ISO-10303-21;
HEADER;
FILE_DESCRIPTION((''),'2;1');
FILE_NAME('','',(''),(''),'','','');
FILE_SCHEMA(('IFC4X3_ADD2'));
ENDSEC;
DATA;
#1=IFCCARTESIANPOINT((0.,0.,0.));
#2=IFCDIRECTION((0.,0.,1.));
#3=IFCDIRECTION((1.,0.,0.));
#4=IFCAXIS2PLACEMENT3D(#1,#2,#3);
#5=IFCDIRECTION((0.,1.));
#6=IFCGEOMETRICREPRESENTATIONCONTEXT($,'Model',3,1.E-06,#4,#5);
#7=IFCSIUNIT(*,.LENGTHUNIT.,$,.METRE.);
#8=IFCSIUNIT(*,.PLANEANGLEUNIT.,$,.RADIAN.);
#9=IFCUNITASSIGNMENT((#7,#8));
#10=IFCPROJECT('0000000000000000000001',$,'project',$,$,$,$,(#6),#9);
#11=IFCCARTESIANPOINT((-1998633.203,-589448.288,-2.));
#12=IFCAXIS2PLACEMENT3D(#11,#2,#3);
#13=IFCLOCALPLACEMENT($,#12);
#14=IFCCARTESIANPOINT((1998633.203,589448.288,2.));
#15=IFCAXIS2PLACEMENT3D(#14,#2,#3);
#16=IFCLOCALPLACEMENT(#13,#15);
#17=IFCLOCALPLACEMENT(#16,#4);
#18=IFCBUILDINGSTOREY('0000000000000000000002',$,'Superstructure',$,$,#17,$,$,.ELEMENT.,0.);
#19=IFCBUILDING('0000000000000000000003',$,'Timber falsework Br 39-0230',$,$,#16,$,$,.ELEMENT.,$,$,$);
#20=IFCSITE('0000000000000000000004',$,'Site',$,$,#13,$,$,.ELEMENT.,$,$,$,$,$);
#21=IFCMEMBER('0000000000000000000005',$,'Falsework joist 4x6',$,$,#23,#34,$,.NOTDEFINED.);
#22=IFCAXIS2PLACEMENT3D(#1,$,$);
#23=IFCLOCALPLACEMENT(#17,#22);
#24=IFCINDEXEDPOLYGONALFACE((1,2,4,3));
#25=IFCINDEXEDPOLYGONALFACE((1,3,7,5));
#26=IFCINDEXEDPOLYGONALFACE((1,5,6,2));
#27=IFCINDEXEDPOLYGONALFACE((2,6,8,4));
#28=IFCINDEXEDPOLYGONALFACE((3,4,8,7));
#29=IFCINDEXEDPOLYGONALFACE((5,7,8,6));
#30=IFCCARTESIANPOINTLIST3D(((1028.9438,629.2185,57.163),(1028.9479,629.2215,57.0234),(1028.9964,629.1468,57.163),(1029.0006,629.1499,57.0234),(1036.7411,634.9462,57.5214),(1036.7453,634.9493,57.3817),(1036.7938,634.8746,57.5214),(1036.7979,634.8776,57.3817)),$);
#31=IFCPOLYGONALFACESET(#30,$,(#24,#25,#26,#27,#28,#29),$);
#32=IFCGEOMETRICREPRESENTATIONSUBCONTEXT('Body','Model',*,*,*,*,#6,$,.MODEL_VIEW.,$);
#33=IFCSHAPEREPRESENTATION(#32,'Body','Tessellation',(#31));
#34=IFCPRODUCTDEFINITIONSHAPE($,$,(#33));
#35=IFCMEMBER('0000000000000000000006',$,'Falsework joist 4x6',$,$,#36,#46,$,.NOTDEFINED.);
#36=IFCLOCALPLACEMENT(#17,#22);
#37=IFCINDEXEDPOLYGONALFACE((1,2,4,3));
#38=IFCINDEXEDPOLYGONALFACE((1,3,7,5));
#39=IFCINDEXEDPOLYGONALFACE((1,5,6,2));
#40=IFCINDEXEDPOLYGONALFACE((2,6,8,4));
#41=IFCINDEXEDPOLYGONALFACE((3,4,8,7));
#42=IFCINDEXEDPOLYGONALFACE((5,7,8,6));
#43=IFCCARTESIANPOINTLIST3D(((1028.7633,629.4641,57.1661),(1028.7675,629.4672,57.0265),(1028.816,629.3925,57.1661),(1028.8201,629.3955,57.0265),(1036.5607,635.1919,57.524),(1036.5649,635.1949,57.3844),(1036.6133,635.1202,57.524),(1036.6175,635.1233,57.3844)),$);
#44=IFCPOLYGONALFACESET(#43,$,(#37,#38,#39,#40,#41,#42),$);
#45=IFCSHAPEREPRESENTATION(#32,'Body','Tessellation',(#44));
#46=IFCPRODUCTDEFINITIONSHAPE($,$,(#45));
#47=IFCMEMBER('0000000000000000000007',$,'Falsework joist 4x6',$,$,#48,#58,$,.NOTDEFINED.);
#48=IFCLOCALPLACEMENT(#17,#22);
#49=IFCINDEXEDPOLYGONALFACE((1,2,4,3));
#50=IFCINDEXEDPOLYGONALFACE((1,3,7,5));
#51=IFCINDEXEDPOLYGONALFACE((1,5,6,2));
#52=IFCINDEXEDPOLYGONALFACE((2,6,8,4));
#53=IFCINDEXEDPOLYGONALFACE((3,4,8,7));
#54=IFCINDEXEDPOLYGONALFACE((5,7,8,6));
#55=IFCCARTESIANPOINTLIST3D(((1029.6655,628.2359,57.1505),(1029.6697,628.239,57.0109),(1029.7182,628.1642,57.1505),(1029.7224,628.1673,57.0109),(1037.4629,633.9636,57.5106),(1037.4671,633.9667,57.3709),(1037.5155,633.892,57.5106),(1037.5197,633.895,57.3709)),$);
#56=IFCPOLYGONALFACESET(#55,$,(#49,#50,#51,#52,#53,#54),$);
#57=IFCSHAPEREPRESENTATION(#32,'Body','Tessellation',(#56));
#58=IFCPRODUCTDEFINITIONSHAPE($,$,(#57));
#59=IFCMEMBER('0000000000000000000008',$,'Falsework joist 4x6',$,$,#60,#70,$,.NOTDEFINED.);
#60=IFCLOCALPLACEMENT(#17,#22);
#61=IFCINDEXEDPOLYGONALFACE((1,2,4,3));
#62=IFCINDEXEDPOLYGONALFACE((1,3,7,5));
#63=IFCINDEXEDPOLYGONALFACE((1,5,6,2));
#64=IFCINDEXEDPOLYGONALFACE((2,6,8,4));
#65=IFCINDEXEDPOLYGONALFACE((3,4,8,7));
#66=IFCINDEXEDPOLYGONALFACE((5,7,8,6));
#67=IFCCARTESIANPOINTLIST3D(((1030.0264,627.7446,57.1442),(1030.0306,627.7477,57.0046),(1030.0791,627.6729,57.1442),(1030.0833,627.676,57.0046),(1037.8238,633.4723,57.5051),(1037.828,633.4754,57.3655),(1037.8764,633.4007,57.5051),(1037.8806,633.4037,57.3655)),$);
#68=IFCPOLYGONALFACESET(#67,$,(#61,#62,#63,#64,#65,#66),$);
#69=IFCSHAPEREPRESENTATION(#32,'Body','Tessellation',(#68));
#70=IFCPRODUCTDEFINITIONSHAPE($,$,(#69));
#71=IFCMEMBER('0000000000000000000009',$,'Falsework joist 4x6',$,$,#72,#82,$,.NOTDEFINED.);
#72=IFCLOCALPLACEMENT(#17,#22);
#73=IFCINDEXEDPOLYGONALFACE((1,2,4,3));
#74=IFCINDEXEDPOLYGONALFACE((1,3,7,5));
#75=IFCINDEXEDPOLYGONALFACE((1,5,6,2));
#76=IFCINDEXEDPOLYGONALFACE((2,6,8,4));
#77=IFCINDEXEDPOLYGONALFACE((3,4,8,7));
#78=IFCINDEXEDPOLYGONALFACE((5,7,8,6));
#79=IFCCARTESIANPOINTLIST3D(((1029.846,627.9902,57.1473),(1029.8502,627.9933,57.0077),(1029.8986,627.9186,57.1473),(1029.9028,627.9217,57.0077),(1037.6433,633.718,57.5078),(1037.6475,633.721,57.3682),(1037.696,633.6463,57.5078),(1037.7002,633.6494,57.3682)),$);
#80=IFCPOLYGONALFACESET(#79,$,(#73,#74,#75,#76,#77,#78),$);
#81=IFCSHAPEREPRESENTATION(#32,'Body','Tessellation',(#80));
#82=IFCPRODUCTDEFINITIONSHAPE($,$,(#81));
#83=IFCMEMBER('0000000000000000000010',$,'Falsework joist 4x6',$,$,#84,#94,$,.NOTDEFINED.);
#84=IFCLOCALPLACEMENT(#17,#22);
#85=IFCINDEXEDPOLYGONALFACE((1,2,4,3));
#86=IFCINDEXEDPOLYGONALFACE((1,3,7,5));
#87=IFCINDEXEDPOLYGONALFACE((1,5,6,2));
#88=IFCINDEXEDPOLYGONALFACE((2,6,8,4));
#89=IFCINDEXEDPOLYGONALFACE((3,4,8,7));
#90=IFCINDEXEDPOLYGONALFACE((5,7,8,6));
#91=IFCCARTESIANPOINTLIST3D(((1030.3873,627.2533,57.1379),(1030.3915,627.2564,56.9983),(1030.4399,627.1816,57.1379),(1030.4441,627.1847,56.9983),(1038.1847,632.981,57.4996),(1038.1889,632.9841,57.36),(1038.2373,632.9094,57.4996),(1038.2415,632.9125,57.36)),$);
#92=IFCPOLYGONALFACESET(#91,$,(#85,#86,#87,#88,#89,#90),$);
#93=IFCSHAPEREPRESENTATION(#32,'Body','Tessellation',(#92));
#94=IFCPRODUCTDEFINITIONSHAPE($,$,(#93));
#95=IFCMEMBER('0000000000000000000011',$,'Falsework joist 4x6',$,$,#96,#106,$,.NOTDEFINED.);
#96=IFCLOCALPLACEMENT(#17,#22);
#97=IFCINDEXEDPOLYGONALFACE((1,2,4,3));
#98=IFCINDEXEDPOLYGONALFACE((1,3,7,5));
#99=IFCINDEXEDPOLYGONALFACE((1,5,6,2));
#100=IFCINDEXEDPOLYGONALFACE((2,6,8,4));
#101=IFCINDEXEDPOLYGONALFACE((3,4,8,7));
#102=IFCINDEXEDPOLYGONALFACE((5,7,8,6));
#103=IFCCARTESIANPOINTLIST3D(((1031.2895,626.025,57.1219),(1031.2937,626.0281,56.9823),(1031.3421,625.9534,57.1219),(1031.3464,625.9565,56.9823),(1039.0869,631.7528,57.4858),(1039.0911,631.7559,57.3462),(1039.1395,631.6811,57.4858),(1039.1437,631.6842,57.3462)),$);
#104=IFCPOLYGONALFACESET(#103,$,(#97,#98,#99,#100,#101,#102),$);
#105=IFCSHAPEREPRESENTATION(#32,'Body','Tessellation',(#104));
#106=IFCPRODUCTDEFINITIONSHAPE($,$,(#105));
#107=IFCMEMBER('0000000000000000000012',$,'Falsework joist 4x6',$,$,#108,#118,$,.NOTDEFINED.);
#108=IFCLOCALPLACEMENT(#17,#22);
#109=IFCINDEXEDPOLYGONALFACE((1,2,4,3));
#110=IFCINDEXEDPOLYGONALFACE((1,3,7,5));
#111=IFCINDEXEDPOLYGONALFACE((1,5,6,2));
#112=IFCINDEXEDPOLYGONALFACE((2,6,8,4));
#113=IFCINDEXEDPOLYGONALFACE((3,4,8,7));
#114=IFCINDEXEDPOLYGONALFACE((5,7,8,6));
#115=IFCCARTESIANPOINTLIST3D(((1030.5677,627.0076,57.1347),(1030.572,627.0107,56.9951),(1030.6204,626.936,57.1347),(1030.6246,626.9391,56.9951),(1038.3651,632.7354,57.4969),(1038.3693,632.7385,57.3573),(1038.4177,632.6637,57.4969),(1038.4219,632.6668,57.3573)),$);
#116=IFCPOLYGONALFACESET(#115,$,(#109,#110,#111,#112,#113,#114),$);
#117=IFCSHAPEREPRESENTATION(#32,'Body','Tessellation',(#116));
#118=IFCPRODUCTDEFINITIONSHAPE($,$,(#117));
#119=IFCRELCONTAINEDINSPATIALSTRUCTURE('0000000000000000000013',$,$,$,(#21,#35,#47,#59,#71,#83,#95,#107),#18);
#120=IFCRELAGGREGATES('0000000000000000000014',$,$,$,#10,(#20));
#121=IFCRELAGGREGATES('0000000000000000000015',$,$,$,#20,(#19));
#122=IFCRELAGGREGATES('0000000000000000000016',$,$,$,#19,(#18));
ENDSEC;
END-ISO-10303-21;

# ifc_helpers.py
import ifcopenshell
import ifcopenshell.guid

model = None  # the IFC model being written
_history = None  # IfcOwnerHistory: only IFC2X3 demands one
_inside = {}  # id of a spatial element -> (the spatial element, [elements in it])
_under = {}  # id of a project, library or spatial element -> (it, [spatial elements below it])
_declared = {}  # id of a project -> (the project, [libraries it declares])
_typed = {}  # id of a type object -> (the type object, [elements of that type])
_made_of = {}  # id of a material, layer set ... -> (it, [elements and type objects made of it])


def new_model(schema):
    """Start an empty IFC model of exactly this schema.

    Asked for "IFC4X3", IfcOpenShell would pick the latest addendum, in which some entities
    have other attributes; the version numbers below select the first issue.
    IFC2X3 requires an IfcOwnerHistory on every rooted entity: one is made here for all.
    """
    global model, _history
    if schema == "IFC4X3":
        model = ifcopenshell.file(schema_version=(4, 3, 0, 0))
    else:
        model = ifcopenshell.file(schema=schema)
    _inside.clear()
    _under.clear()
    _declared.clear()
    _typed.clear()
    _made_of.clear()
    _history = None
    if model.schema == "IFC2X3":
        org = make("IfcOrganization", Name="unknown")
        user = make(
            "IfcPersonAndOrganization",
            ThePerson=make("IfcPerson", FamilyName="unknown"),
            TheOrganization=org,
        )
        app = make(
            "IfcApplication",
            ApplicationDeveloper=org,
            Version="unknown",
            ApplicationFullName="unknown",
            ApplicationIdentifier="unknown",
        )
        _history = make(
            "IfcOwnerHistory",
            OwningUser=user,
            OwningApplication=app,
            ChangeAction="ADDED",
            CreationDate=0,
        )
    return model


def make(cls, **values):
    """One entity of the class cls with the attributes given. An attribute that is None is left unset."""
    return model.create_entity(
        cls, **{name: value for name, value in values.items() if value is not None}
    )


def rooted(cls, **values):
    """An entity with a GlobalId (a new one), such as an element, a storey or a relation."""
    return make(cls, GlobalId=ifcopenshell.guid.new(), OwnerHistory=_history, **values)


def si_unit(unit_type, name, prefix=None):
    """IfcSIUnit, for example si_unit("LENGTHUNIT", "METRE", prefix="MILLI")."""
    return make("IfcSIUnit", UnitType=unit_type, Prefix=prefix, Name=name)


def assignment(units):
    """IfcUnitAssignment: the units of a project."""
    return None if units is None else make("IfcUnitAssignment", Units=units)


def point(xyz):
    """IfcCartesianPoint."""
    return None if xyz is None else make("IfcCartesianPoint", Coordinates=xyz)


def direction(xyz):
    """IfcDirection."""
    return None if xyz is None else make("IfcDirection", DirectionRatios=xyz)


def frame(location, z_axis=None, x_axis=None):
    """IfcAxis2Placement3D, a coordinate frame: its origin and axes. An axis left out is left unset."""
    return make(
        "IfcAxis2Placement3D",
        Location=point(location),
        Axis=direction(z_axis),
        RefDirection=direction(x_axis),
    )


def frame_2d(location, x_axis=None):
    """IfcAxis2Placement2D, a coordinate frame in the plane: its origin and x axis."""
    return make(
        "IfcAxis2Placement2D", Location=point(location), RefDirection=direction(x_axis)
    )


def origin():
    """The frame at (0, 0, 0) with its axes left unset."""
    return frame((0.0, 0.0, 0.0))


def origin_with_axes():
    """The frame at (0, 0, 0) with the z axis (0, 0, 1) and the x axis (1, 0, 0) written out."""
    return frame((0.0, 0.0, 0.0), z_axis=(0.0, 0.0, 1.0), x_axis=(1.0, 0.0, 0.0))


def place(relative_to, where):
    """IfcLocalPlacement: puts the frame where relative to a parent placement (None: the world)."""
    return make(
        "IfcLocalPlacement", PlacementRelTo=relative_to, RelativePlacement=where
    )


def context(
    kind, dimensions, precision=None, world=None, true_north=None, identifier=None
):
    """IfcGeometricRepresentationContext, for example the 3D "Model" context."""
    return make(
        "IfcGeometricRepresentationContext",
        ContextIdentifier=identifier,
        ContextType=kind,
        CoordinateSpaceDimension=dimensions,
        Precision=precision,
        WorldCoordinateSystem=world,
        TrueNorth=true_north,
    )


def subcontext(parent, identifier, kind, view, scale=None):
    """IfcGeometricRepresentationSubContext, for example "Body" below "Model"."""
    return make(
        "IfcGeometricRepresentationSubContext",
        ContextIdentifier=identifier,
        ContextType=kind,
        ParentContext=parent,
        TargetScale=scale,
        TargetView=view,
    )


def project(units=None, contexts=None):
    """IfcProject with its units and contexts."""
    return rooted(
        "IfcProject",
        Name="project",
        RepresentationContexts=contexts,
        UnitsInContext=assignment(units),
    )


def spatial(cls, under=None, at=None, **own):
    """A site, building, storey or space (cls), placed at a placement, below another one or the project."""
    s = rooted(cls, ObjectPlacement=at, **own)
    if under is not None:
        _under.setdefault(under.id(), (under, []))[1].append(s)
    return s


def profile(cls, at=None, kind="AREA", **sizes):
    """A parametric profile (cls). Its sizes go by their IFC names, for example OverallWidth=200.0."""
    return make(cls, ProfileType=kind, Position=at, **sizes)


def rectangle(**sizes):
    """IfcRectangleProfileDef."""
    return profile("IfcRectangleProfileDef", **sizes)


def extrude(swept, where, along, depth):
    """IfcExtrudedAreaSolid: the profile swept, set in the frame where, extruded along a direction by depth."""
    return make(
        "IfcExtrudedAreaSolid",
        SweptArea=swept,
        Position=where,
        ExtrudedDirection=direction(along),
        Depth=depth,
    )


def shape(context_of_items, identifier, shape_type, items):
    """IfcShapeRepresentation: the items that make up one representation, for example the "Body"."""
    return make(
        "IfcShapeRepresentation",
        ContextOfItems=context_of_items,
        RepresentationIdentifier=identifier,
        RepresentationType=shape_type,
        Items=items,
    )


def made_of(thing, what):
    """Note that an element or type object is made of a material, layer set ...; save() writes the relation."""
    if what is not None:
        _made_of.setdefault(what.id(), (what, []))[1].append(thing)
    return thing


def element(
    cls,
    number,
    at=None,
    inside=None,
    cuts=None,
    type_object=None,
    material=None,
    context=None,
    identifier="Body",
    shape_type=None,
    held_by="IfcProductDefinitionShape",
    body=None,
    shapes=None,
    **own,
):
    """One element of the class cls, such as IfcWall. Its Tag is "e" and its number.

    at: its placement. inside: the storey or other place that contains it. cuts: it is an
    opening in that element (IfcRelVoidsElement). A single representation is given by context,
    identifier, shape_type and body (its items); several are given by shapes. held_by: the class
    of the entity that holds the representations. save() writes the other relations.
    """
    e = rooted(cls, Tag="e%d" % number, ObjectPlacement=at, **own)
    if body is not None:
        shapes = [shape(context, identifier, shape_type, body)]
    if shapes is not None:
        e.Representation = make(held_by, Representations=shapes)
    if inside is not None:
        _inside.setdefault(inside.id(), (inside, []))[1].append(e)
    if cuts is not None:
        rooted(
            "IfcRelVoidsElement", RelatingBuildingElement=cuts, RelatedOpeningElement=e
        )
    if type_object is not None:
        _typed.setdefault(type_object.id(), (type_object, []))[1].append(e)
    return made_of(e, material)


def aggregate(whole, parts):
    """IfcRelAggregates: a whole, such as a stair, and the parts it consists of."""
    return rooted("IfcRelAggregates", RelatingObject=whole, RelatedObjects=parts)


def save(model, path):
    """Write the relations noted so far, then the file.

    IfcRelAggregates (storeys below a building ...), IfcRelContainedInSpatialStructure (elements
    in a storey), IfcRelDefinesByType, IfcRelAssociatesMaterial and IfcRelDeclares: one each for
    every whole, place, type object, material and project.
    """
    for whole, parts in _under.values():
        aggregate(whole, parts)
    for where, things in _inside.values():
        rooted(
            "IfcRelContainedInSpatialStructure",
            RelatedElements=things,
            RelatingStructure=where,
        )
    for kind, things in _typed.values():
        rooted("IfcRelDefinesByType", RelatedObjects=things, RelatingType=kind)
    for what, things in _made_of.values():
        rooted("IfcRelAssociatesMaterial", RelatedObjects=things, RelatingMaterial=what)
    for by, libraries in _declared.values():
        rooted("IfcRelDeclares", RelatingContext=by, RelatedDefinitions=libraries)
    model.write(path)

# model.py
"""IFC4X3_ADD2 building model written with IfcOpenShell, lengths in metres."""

from ifc_helpers import new_model, si_unit, direction, frame, frame_2d, origin, origin_with_axes, place, context, subcontext, project, spatial, rectangle, extrude, element, save


model = new_model("IFC4X3_ADD2")

# Units and contexts
model_context = context("Model", 3, precision=1e-06, world=origin_with_axes(), true_north=direction((0.0, 1.0)))
body_context = subcontext(model_context, "Body", "Model", "MODEL_VIEW")
ifc_project = project(units=[si_unit("LENGTHUNIT", "METRE"), si_unit("PLANEANGLEUNIT", "RADIAN")], contexts=[model_context])

# Site, building, storey
site_placement = place(None, frame((-1998633.203, -589448.288, -2.0), z_axis=(0.0, 0.0, 1.0), x_axis=(1.0, 0.0, 0.0)))
site = spatial("IfcSite", under=ifc_project, at=site_placement, Name="Site", CompositionType="ELEMENT")
building_placement = place(site_placement, frame((1998633.203, 589448.288, 2.0), z_axis=(0.0, 0.0, 1.0), x_axis=(1.0, 0.0, 0.0)))
building = spatial("IfcBuilding", under=site, at=building_placement, Name="Timber falsework Br 39-0230", CompositionType="ELEMENT")
storey_placement = place(building_placement, origin_with_axes())
storey = spatial("IfcBuildingStorey", under=building, at=storey_placement, Name="Superstructure", CompositionType="ELEMENT", Elevation=0.0)

# Members
member_1_placement = place(storey_placement, frame((1028.9743, 629.1857, 57.0234), z_axis=(0.805376, 0.591607, 0.037014), x_axis=(-0.592013, 0.805928, 0.0)))
element("IfcMember", 1, at=member_1_placement, inside=storey, Name="Falsework joist 4x6", PredefinedType="NOTDEFINED", context=body_context, shape_type="SweptSolid", body=[
    extrude(rectangle(XDim=0.0889, YDim=0.1397, at=frame_2d((0.0, 0.0698))), origin(), (0.0, 0.0, 1.0), 9.6816),
])
member_2_placement = place(storey_placement, frame((1028.7938, 629.4314, 57.0265), z_axis=(0.805377, 0.591608, 0.036971), x_axis=(-0.592013, 0.805928, 0.0)))
element("IfcMember", 2, at=member_2_placement, inside=storey, Name="Falsework joist 4x6", PredefinedType="NOTDEFINED", context=body_context, shape_type="SweptSolid", body=[
    extrude(rectangle(XDim=0.0889, YDim=0.1397, at=frame_2d((0.0, 0.0698))), origin(), (0.0, 0.0, 1.0), 9.6816),
])
member_3_placement = place(storey_placement, frame((1029.696, 628.2031, 57.0109), z_axis=(0.805371, 0.591604, 0.03719), x_axis=(-0.592013, 0.805928, 0.0)))
element("IfcMember", 3, at=member_3_placement, inside=storey, Name="Falsework joist 4x6", PredefinedType="NOTDEFINED", context=body_context, shape_type="SweptSolid", body=[
    extrude(rectangle(XDim=0.0889, YDim=0.1397, at=frame_2d((0.0, 0.0698))), origin(), (0.0, 0.0, 1.0), 9.6817),
])
member_4_placement = place(storey_placement, frame((1030.0569, 627.7118, 57.0046), z_axis=(0.805368, 0.591602, 0.037277), x_axis=(-0.592013, 0.805928, 0.0)))
element("IfcMember", 4, at=member_4_placement, inside=storey, Name="Falsework joist 4x6", PredefinedType="NOTDEFINED", context=body_context, shape_type="SweptSolid", body=[
    extrude(rectangle(XDim=0.0889, YDim=0.1397, at=frame_2d((0.0, 0.0698))), origin(), (0.0, 0.0, 1.0), 9.6817),
])
member_5_placement = place(storey_placement, frame((1029.8765, 627.9575, 57.0077), z_axis=(0.805369, 0.591603, 0.037233), x_axis=(-0.592013, 0.805928, 0.0)))
element("IfcMember", 5, at=member_5_placement, inside=storey, Name="Falsework joist 4x6", PredefinedType="NOTDEFINED", context=body_context, shape_type="SweptSolid", body=[
    extrude(rectangle(XDim=0.0889, YDim=0.1397, at=frame_2d((0.0, 0.0698))), origin(), (0.0, 0.0, 1.0), 9.6817),
])
member_6_placement = place(storey_placement, frame((1030.4178, 627.2205, 56.9983), z_axis=(0.805366, 0.5916, 0.037364), x_axis=(-0.592013, 0.805928, 0.0)))
element("IfcMember", 6, at=member_6_placement, inside=storey, Name="Falsework joist 4x6", PredefinedType="NOTDEFINED", context=body_context, shape_type="SweptSolid", body=[
    extrude(rectangle(XDim=0.0889, YDim=0.1397, at=frame_2d((0.0, 0.0698))), origin(), (0.0, 0.0, 1.0), 9.6818),
])
member_7_placement = place(storey_placement, frame((1031.3201, 625.9923, 56.9823), z_axis=(0.805359, 0.591595, 0.037586), x_axis=(-0.592013, 0.805928, 0.0)))
element("IfcMember", 7, at=member_7_placement, inside=storey, Name="Falsework joist 4x6", PredefinedType="NOTDEFINED", context=body_context, shape_type="SweptSolid", body=[
    extrude(rectangle(XDim=0.0889, YDim=0.1397, at=frame_2d((0.0, 0.0698))), origin(), (0.0, 0.0, 1.0), 9.6818),
])
member_8_placement = place(storey_placement, frame((1030.5983, 626.9749, 56.9951), z_axis=(0.805364, 0.591599, 0.037408), x_axis=(-0.592013, 0.805928, 0.0)))
element("IfcMember", 8, at=member_8_placement, inside=storey, Name="Falsework joist 4x6", PredefinedType="NOTDEFINED", context=body_context, shape_type="SweptSolid", body=[
    extrude(rectangle(XDim=0.0889, YDim=0.1397, at=frame_2d((0.0, 0.0698))), origin(), (0.0, 0.0, 1.0), 9.6818),
])

save(model, "model.ifc")
